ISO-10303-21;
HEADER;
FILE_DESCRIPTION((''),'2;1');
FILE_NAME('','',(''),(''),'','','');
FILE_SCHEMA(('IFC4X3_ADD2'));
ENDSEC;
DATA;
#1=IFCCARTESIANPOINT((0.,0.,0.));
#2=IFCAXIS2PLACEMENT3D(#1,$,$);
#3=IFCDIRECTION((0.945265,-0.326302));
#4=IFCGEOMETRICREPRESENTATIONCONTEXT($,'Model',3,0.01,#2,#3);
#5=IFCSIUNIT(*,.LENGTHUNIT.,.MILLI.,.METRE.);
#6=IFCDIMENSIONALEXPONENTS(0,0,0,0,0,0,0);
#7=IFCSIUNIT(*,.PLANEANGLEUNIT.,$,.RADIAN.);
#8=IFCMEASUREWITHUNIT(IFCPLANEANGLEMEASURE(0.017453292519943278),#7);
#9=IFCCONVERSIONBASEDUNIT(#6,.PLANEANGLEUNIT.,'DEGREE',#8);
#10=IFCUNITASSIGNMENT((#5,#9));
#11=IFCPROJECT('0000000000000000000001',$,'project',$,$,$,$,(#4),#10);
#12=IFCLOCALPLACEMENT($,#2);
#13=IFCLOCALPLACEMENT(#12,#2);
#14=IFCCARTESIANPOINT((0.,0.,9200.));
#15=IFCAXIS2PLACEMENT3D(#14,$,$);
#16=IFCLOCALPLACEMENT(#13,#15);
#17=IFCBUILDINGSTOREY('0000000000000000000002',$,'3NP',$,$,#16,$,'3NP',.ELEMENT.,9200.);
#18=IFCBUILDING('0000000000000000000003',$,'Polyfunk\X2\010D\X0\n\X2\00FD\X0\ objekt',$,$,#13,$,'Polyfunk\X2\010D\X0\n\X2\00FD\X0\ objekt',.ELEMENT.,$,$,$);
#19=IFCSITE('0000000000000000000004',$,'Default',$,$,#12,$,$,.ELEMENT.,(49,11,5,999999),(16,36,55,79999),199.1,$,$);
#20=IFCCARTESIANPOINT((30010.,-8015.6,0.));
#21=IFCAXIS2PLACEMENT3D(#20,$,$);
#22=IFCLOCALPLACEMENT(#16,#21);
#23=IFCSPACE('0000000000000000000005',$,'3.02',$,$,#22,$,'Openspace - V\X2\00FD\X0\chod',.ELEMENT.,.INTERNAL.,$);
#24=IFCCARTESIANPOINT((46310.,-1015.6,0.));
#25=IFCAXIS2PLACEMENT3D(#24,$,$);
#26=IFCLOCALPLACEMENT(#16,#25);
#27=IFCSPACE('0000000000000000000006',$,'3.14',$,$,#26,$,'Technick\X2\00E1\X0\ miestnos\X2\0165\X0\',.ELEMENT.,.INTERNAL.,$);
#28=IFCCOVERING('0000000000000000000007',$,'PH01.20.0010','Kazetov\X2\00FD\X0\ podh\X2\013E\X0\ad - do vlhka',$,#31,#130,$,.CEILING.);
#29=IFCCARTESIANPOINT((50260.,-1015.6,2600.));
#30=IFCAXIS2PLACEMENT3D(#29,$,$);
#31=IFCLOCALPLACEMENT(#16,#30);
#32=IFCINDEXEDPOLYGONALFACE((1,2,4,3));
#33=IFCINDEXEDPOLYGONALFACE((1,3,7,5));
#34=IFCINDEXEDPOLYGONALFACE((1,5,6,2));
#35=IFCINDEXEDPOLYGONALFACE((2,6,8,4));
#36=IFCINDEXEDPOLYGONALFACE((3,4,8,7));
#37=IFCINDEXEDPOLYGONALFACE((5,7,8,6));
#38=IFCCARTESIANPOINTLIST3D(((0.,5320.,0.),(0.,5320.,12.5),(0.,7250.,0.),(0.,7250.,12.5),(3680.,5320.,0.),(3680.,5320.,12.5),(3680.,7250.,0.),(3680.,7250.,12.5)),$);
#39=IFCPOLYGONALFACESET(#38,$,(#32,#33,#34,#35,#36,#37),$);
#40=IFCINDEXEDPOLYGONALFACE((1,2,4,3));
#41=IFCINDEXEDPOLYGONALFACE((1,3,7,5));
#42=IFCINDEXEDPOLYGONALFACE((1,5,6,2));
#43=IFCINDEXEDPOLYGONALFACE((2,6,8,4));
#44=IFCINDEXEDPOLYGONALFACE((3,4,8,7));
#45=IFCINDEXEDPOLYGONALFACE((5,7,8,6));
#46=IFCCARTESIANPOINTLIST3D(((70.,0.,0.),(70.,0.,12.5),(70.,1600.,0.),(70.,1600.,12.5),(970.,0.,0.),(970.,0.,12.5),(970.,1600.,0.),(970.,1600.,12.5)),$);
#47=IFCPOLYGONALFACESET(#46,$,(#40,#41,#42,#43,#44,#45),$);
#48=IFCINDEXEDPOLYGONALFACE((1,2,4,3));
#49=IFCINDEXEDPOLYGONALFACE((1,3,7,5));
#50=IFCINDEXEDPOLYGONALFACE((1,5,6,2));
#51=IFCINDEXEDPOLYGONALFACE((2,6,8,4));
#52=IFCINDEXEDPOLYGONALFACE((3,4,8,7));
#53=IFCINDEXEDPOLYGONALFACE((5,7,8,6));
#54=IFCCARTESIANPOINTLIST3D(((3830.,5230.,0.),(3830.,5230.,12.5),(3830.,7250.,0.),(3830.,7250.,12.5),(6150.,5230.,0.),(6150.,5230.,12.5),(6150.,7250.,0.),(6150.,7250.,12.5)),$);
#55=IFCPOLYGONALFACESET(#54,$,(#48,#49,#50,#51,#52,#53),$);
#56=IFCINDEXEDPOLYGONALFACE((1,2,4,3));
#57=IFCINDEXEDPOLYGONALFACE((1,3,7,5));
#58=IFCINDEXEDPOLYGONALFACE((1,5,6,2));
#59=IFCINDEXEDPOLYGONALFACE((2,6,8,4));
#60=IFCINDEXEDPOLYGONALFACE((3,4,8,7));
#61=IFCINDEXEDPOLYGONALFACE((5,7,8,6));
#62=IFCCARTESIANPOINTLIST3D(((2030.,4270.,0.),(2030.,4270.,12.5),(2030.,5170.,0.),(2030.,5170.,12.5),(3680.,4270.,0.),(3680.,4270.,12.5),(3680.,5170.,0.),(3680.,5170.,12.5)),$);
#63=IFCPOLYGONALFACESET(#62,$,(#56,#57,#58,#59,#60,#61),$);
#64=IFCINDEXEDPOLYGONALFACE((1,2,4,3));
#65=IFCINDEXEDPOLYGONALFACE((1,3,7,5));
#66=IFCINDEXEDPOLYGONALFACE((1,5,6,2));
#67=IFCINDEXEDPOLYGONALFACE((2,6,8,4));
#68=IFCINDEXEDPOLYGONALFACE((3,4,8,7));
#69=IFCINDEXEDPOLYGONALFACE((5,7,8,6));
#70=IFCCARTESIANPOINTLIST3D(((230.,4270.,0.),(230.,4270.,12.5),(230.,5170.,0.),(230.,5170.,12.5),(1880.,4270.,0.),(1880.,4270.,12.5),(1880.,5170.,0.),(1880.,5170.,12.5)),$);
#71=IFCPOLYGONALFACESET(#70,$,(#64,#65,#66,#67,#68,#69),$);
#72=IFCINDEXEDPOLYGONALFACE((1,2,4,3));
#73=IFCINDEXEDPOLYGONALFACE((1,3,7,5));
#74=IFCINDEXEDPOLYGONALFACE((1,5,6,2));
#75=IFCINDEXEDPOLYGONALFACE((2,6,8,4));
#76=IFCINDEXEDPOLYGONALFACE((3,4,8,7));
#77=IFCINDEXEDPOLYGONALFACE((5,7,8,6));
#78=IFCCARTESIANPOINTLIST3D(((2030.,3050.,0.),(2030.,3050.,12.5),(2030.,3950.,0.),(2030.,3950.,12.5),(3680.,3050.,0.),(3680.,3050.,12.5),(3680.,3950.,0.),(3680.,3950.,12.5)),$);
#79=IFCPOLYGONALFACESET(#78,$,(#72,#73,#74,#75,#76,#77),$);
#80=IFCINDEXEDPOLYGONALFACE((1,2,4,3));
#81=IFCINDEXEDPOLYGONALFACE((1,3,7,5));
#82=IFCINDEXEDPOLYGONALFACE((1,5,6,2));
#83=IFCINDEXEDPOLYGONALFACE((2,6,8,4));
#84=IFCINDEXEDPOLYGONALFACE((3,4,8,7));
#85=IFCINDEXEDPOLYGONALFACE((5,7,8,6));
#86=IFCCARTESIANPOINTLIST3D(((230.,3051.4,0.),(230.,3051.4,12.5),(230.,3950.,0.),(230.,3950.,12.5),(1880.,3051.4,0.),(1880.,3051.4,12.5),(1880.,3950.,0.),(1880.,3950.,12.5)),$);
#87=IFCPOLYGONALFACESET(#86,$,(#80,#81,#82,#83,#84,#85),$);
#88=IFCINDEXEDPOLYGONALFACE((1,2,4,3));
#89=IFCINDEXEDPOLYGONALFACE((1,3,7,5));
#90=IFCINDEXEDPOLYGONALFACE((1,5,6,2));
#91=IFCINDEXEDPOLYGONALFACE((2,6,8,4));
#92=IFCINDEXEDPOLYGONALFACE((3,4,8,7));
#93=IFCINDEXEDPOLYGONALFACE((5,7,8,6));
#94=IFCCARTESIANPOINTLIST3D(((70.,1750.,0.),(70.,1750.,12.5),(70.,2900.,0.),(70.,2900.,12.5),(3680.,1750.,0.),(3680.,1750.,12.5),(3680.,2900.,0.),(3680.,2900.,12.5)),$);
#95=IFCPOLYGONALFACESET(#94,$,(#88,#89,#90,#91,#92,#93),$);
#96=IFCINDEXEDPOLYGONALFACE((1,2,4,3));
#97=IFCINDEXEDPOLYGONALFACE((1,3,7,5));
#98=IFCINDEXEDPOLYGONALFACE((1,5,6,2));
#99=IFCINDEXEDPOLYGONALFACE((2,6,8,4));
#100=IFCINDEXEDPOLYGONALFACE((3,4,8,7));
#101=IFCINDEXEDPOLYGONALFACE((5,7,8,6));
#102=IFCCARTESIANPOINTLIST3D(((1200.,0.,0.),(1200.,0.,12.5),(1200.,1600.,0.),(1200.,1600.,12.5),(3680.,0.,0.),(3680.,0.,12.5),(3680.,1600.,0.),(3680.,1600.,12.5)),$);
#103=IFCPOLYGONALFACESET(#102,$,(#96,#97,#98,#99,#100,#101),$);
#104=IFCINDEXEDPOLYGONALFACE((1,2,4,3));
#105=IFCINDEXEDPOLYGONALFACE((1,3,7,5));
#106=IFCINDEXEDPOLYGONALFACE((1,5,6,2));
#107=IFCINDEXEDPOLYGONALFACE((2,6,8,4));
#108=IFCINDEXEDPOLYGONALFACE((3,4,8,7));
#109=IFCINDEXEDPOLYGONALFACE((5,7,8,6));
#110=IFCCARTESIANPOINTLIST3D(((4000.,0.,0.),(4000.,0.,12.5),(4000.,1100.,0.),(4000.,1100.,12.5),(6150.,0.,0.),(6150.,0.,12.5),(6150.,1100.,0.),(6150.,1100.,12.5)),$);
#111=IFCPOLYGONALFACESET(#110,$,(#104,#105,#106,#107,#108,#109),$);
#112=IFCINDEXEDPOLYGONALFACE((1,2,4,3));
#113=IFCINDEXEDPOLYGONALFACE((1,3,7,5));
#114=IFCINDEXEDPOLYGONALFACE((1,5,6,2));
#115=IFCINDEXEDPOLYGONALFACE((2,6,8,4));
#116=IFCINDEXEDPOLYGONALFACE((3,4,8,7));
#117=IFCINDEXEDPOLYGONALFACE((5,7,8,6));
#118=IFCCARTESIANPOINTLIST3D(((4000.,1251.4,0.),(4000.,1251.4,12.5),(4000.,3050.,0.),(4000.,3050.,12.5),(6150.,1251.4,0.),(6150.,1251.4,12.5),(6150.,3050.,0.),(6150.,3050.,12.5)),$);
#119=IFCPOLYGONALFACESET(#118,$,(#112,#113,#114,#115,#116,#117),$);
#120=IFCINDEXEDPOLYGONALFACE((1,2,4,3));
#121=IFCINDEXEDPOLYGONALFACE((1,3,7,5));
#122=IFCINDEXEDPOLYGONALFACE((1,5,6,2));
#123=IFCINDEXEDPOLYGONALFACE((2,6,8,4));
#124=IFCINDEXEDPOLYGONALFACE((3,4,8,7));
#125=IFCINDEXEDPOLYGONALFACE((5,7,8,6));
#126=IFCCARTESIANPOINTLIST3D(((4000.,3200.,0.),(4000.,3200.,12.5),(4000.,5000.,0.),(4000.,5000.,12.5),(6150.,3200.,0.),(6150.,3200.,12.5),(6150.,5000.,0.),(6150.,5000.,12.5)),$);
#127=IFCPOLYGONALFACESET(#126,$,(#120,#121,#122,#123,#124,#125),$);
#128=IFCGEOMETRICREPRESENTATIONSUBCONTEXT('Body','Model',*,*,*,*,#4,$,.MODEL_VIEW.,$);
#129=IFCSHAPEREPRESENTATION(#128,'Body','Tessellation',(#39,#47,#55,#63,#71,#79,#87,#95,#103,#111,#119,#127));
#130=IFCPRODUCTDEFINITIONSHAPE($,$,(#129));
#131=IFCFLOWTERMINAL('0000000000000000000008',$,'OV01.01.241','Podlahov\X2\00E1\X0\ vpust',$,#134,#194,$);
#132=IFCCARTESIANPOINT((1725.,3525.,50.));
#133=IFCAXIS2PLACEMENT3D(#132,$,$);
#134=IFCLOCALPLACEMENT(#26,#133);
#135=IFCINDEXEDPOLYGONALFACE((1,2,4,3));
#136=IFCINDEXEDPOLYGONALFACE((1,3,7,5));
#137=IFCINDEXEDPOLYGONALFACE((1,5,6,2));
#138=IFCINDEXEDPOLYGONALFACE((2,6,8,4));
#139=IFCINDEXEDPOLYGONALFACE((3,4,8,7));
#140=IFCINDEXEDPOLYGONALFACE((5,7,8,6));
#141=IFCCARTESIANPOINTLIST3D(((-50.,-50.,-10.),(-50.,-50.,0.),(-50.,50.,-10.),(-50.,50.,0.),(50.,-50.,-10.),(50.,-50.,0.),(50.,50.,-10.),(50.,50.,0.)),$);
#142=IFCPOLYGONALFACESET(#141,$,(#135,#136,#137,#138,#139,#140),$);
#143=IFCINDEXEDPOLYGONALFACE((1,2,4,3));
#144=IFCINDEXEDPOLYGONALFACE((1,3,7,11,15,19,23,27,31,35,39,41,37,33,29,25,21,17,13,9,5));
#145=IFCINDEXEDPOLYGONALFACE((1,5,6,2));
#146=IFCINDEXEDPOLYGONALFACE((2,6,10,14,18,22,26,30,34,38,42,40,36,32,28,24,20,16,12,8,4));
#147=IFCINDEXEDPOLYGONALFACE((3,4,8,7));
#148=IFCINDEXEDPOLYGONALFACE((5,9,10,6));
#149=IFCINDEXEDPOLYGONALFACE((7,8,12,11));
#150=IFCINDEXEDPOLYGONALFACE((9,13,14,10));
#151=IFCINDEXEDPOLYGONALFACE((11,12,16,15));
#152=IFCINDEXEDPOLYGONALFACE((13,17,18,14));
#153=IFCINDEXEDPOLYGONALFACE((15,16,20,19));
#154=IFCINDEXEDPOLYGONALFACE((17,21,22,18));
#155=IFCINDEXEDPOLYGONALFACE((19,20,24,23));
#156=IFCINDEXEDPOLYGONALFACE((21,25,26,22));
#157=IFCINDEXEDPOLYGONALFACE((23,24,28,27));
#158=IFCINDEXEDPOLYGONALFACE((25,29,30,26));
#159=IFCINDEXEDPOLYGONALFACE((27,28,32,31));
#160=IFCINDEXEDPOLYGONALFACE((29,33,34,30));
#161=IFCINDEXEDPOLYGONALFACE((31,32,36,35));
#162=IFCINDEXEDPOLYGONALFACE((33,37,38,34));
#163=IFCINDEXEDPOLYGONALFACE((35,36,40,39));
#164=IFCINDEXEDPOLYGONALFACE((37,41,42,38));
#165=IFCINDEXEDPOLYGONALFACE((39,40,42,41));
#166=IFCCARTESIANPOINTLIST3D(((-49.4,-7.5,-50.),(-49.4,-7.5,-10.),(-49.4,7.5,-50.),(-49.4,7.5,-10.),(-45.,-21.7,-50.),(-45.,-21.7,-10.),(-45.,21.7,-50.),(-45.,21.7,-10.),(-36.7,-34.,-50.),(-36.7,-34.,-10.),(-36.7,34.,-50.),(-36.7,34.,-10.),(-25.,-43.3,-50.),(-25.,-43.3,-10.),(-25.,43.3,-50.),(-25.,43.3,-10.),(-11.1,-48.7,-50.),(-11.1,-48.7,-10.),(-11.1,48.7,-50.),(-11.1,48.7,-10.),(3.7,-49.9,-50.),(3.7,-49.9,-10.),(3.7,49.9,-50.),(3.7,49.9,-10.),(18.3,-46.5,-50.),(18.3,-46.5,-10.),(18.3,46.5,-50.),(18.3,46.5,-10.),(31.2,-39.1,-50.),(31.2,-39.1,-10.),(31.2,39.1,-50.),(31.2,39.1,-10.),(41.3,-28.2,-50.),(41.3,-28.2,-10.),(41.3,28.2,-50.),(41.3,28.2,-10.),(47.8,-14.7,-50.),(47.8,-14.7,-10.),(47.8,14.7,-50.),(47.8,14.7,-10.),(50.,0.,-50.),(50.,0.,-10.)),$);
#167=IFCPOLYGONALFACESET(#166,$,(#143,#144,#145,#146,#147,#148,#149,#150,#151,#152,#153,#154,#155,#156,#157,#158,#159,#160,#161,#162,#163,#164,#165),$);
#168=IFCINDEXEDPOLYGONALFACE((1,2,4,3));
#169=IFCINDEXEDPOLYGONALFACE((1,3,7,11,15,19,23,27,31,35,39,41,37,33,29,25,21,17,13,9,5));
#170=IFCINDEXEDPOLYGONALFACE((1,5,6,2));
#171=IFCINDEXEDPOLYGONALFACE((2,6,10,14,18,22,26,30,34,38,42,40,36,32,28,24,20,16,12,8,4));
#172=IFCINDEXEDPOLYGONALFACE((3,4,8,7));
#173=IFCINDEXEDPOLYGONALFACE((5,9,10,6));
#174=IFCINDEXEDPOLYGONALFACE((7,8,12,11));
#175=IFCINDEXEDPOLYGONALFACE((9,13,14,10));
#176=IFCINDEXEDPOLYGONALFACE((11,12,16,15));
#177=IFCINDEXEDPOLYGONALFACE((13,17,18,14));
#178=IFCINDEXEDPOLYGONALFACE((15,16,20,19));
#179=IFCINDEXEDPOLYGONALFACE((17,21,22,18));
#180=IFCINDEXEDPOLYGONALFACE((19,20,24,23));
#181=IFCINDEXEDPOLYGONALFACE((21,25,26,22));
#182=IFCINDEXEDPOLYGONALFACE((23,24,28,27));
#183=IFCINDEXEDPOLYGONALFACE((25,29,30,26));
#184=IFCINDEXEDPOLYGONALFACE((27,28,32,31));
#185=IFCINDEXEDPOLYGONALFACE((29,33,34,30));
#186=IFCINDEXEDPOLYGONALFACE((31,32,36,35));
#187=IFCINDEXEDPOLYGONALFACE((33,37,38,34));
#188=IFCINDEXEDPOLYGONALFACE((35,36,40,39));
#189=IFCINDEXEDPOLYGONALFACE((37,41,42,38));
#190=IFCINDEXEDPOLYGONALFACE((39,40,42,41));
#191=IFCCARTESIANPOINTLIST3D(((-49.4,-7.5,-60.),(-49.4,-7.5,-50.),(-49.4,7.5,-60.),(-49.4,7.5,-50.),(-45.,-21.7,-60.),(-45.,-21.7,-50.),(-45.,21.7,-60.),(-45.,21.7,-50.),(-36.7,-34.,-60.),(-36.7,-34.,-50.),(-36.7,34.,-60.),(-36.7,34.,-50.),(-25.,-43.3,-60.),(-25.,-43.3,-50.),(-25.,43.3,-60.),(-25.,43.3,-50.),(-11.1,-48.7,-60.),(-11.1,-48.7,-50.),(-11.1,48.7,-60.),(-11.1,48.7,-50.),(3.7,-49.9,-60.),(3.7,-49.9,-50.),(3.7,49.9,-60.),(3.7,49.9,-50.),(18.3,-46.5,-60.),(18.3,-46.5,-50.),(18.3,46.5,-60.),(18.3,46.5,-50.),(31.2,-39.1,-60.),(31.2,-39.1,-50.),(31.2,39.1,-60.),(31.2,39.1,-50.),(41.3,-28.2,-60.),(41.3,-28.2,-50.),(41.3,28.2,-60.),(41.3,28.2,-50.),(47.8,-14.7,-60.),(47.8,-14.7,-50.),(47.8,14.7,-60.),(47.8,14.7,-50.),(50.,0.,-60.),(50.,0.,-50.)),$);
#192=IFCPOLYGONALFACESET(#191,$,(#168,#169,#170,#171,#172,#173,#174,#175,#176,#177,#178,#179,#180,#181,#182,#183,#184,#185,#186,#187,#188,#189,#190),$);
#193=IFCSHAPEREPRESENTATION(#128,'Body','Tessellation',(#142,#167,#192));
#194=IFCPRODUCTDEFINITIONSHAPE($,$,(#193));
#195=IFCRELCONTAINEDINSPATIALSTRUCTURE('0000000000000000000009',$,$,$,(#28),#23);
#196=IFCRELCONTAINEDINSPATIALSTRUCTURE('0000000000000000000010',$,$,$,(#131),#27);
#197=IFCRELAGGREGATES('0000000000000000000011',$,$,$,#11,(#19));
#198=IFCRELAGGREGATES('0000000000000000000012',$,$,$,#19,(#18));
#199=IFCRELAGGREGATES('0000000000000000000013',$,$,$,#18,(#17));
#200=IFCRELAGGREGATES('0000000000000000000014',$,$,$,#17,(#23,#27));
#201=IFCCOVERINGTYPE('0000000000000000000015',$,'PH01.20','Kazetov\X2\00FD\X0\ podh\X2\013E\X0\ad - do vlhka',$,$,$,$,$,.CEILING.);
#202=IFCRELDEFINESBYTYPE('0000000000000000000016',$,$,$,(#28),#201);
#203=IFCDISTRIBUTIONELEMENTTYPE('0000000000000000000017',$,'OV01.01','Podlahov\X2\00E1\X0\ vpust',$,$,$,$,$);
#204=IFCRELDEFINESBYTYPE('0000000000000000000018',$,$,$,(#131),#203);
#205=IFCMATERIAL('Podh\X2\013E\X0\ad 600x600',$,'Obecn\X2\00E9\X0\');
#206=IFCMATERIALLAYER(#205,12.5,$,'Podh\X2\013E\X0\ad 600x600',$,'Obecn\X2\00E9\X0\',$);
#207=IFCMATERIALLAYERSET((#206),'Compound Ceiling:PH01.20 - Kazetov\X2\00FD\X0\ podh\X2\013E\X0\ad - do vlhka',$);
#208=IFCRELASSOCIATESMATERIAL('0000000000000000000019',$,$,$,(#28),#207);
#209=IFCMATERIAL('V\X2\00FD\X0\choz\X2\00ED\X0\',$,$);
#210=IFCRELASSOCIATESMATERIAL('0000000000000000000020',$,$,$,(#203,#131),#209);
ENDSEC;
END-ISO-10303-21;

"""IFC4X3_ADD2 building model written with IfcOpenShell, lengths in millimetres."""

from ifc_helpers import new_model, entity, si_unit, converted_unit, direction, frame, frame_2d, origin, origin_2d_with_axis, place, context, subcontext, project, spatial, rectangle, circle, extrude, source, transform, mapped, material, layer, layer_set, layer_usage, type_object, type_shapes, element, save


model = new_model("IFC4X3_ADD2")

# Units and contexts
model_context = context("Model", 3, precision=0.01, world=origin(), true_north=direction((0.945265, -0.326302)))
body_context = subcontext(model_context, "Body", "Model", "MODEL_VIEW")
ifc_project = project(units=[si_unit("LENGTHUNIT", "METRE", prefix="MILLI"), converted_unit("PLANEANGLEUNIT", "DEGREE", entity("IfcPlaneAngleMeasure", 0.017453292519943278), si_unit("PLANEANGLEUNIT", "RADIAN"), dimensions=[0, 0, 0, 0, 0, 0, 0])], contexts=[model_context])

# Site, building, storey
site_placement = place(None, origin())
site = spatial("IfcSite", under=ifc_project, at=site_placement, Name="Default", CompositionType="ELEMENT", RefLatitude=(49, 11, 5, 999999), RefLongitude=(16, 36, 55, 79999), RefElevation=199.1)
building_placement = place(site_placement, origin())
building = spatial("IfcBuilding", under=site, at=building_placement, Name="Polyfunkčný objekt", LongName="Polyfunkčný objekt", CompositionType="ELEMENT")
storey_placement = place(building_placement, frame((0.0, 0.0, 9200.0)))
storey = spatial("IfcBuildingStorey", under=building, at=storey_placement, Name="3NP", LongName="3NP", CompositionType="ELEMENT", Elevation=9200.0)

# Shared definitions
space_1_placement = place(storey_placement, frame((30010.0, -8015.6, 0.0)))
space_1 = spatial("IfcSpace", under=storey, at=space_1_placement, Name="3.02", LongName="Openspace - Východ", CompositionType="ELEMENT", PredefinedType="INTERNAL")

# Covering
ifc_material_1 = material(Name="Podhľad 600x600", Category="Obecné")
ifc_layer_1 = layer(ifc_material_1, 12.5, Name="Podhľad 600x600", Category="Obecné")
ifc_layer_set_1 = layer_set([ifc_layer_1], Name="Compound Ceiling:PH01.20 - Kazetový podhľad - do vlhka")
ifc_layer_usage_1 = layer_usage(ifc_layer_set_1, "AXIS3", "NEGATIVE", 0.0)
covering_type = type_object("IfcCoveringType", Name="PH01.20", Description="Kazetový podhľad - do vlhka", PredefinedType="CEILING")
covering_placement = place(storey_placement, frame((50260.0, -1015.6, 2600.0)))
element("IfcCovering", 1, at=covering_placement, inside=space_1, type_object=covering_type, material=ifc_layer_usage_1, Name="PH01.20.0010", Description="Kazetový podhľad - do vlhka", PredefinedType="CEILING", context=body_context, shape_type="SweptSolid", body=[
    extrude(rectangle(XDim=1930.0, YDim=3680.0, at=frame_2d((0.0, 0.0), x_axis=(1.0, 0.0))), frame((1840.0, 6285.0, 0.0), z_axis=(0.0, 0.0, 1.0), x_axis=(0.0, -1.0, 0.0)), (0.0, 0.0, 1.0), 12.5),
    extrude(rectangle(XDim=1600.0, YDim=900.0, at=origin_2d_with_axis()), frame((520.0, 800.0, 0.0), z_axis=(0.0, 0.0, 1.0), x_axis=(0.0, 1.0, 0.0)), (0.0, 0.0, 1.0), 12.5),
    extrude(rectangle(XDim=2320.0, YDim=2020.0, at=frame_2d((0.0, 0.0), x_axis=(1.0, 0.0))), frame((4990.0, 6240.0, 0.0), z_axis=(0.0, 0.0, 1.0), x_axis=(-1.0, 0.0, 0.0)), (0.0, 0.0, 1.0), 12.5),
    extrude(rectangle(XDim=900.0, YDim=1650.0, at=frame_2d((0.0, 0.0), x_axis=(1.0, 0.0))), frame((2855.0, 4720.0, 0.0), z_axis=(0.0, 0.0, 1.0), x_axis=(0.0, 1.0, 0.0)), (0.0, 0.0, 1.0), 12.5),
    extrude(rectangle(XDim=1650.0, YDim=900.0, at=frame_2d((0.0, 0.0), x_axis=(1.0, 0.0))), frame((1055.0, 4720.0, 0.0), z_axis=(0.0, 0.0, 1.0), x_axis=(-1.0, 0.0, 0.0)), (0.0, 0.0, 1.0), 12.5),
    extrude(rectangle(XDim=900.0, YDim=1650.0, at=frame_2d((0.0, 0.0), x_axis=(1.0, 0.0))), frame((2855.0, 3500.0, 0.0), z_axis=(0.0, 0.0, 1.0), x_axis=(0.0, -1.0, 0.0)), (0.0, 0.0, 1.0), 12.5),
    extrude(rectangle(XDim=1650.0, YDim=898.6, at=frame_2d((0.0, 0.0), x_axis=(1.0, 0.0))), frame((1055.0, 3500.7, 0.0), z_axis=(0.0, 0.0, 1.0), x_axis=(-1.0, 0.0, 0.0)), (0.0, 0.0, 1.0), 12.5),
    extrude(rectangle(XDim=3610.0, YDim=1150.0, at=frame_2d((0.0, 0.0), x_axis=(1.0, 0.0))), frame((1875.0, 2325.0, 0.0), z_axis=(0.0, 0.0, 1.0), x_axis=(-1.0, 0.0, 0.0)), (0.0, 0.0, 1.0), 12.5),
    extrude(rectangle(XDim=2480.0, YDim=1600.0, at=origin_2d_with_axis()), frame((2440.0, 800.0, 0.0), z_axis=(0.0, 0.0, 1.0), x_axis=(-1.0, 0.0, 0.0)), (0.0, 0.0, 1.0), 12.5),
    extrude(rectangle(XDim=1100.0, YDim=2150.0, at=frame_2d((0.0, 0.0), x_axis=(1.0, 0.0))), frame((5075.0, 550.0, 0.0), z_axis=(0.0, 0.0, 1.0), x_axis=(0.0, 1.0, 0.0)), (0.0, 0.0, 1.0), 12.5),
    extrude(rectangle(XDim=1798.6, YDim=2150.0, at=origin_2d_with_axis()), frame((5075.0, 2150.7, 0.0), z_axis=(0.0, 0.0, 1.0), x_axis=(0.0, 1.0, 0.0)), (0.0, 0.0, 1.0), 12.5),
    extrude(rectangle(XDim=1800.0, YDim=2150.0, at=frame_2d((0.0, 0.0), x_axis=(1.0, 0.0))), frame((5075.0, 4100.0, 0.0), z_axis=(0.0, 0.0, 1.0), x_axis=(0.0, 1.0, 0.0)), (0.0, 0.0, 1.0), 12.5),
])

# Shared definitions
space_2_placement = place(storey_placement, frame((46310.0, -1015.6, 0.0)))
space_2 = spatial("IfcSpace", under=storey, at=space_2_placement, Name="3.14", LongName="Technická miestnosť", CompositionType="ELEMENT", PredefinedType="INTERNAL")

# Flow terminal
ifc_material_2 = material(Name="Výchozí")
distribution_element_type = type_object("IfcDistributionElementType", Name="OV01.01", Description="Podlahová vpust", material=ifc_material_2)
shared_shape_1 = source(origin(), body_context, "Body", "SweptSolid", [
    extrude(rectangle(XDim=100.0, YDim=100.0, at=frame_2d((0.0, 0.0), x_axis=(1.0, 0.0))), frame((0.0, 0.0, -10.0), z_axis=(0.0, 0.0, 1.0), x_axis=(-1.0, 0.0, 0.0)), (0.0, 0.0, 1.0), 10.0),
    extrude(circle(Radius=50.0, at=frame_2d((0.0, 0.0), x_axis=(1.0, 0.0))), frame((0.0, 0.0, -50.0)), (0.0, 0.0, 1.0), 40.0),
    extrude(circle(Radius=50.0, at=frame_2d((0.0, 0.0), x_axis=(1.0, 0.0))), frame((0.0, 0.0, -60.0)), (0.0, 0.0, 1.0), 10.0),
])
type_shapes(distribution_element_type, [shared_shape_1])
flow_terminal_placement = place(space_2_placement, frame((1725.0, 3525.0, 50.0)))
element("IfcFlowTerminal", 2, at=flow_terminal_placement, inside=space_2, type_object=distribution_element_type, material=ifc_material_2, Name="OV01.01.241", Description="Podlahová vpust", context=body_context, shape_type="MappedRepresentation", body=[
    mapped(shared_shape_1, transform((0.0, 0.0, 0.0), scale=1.0)),
])

save(model, "model.ifc")
